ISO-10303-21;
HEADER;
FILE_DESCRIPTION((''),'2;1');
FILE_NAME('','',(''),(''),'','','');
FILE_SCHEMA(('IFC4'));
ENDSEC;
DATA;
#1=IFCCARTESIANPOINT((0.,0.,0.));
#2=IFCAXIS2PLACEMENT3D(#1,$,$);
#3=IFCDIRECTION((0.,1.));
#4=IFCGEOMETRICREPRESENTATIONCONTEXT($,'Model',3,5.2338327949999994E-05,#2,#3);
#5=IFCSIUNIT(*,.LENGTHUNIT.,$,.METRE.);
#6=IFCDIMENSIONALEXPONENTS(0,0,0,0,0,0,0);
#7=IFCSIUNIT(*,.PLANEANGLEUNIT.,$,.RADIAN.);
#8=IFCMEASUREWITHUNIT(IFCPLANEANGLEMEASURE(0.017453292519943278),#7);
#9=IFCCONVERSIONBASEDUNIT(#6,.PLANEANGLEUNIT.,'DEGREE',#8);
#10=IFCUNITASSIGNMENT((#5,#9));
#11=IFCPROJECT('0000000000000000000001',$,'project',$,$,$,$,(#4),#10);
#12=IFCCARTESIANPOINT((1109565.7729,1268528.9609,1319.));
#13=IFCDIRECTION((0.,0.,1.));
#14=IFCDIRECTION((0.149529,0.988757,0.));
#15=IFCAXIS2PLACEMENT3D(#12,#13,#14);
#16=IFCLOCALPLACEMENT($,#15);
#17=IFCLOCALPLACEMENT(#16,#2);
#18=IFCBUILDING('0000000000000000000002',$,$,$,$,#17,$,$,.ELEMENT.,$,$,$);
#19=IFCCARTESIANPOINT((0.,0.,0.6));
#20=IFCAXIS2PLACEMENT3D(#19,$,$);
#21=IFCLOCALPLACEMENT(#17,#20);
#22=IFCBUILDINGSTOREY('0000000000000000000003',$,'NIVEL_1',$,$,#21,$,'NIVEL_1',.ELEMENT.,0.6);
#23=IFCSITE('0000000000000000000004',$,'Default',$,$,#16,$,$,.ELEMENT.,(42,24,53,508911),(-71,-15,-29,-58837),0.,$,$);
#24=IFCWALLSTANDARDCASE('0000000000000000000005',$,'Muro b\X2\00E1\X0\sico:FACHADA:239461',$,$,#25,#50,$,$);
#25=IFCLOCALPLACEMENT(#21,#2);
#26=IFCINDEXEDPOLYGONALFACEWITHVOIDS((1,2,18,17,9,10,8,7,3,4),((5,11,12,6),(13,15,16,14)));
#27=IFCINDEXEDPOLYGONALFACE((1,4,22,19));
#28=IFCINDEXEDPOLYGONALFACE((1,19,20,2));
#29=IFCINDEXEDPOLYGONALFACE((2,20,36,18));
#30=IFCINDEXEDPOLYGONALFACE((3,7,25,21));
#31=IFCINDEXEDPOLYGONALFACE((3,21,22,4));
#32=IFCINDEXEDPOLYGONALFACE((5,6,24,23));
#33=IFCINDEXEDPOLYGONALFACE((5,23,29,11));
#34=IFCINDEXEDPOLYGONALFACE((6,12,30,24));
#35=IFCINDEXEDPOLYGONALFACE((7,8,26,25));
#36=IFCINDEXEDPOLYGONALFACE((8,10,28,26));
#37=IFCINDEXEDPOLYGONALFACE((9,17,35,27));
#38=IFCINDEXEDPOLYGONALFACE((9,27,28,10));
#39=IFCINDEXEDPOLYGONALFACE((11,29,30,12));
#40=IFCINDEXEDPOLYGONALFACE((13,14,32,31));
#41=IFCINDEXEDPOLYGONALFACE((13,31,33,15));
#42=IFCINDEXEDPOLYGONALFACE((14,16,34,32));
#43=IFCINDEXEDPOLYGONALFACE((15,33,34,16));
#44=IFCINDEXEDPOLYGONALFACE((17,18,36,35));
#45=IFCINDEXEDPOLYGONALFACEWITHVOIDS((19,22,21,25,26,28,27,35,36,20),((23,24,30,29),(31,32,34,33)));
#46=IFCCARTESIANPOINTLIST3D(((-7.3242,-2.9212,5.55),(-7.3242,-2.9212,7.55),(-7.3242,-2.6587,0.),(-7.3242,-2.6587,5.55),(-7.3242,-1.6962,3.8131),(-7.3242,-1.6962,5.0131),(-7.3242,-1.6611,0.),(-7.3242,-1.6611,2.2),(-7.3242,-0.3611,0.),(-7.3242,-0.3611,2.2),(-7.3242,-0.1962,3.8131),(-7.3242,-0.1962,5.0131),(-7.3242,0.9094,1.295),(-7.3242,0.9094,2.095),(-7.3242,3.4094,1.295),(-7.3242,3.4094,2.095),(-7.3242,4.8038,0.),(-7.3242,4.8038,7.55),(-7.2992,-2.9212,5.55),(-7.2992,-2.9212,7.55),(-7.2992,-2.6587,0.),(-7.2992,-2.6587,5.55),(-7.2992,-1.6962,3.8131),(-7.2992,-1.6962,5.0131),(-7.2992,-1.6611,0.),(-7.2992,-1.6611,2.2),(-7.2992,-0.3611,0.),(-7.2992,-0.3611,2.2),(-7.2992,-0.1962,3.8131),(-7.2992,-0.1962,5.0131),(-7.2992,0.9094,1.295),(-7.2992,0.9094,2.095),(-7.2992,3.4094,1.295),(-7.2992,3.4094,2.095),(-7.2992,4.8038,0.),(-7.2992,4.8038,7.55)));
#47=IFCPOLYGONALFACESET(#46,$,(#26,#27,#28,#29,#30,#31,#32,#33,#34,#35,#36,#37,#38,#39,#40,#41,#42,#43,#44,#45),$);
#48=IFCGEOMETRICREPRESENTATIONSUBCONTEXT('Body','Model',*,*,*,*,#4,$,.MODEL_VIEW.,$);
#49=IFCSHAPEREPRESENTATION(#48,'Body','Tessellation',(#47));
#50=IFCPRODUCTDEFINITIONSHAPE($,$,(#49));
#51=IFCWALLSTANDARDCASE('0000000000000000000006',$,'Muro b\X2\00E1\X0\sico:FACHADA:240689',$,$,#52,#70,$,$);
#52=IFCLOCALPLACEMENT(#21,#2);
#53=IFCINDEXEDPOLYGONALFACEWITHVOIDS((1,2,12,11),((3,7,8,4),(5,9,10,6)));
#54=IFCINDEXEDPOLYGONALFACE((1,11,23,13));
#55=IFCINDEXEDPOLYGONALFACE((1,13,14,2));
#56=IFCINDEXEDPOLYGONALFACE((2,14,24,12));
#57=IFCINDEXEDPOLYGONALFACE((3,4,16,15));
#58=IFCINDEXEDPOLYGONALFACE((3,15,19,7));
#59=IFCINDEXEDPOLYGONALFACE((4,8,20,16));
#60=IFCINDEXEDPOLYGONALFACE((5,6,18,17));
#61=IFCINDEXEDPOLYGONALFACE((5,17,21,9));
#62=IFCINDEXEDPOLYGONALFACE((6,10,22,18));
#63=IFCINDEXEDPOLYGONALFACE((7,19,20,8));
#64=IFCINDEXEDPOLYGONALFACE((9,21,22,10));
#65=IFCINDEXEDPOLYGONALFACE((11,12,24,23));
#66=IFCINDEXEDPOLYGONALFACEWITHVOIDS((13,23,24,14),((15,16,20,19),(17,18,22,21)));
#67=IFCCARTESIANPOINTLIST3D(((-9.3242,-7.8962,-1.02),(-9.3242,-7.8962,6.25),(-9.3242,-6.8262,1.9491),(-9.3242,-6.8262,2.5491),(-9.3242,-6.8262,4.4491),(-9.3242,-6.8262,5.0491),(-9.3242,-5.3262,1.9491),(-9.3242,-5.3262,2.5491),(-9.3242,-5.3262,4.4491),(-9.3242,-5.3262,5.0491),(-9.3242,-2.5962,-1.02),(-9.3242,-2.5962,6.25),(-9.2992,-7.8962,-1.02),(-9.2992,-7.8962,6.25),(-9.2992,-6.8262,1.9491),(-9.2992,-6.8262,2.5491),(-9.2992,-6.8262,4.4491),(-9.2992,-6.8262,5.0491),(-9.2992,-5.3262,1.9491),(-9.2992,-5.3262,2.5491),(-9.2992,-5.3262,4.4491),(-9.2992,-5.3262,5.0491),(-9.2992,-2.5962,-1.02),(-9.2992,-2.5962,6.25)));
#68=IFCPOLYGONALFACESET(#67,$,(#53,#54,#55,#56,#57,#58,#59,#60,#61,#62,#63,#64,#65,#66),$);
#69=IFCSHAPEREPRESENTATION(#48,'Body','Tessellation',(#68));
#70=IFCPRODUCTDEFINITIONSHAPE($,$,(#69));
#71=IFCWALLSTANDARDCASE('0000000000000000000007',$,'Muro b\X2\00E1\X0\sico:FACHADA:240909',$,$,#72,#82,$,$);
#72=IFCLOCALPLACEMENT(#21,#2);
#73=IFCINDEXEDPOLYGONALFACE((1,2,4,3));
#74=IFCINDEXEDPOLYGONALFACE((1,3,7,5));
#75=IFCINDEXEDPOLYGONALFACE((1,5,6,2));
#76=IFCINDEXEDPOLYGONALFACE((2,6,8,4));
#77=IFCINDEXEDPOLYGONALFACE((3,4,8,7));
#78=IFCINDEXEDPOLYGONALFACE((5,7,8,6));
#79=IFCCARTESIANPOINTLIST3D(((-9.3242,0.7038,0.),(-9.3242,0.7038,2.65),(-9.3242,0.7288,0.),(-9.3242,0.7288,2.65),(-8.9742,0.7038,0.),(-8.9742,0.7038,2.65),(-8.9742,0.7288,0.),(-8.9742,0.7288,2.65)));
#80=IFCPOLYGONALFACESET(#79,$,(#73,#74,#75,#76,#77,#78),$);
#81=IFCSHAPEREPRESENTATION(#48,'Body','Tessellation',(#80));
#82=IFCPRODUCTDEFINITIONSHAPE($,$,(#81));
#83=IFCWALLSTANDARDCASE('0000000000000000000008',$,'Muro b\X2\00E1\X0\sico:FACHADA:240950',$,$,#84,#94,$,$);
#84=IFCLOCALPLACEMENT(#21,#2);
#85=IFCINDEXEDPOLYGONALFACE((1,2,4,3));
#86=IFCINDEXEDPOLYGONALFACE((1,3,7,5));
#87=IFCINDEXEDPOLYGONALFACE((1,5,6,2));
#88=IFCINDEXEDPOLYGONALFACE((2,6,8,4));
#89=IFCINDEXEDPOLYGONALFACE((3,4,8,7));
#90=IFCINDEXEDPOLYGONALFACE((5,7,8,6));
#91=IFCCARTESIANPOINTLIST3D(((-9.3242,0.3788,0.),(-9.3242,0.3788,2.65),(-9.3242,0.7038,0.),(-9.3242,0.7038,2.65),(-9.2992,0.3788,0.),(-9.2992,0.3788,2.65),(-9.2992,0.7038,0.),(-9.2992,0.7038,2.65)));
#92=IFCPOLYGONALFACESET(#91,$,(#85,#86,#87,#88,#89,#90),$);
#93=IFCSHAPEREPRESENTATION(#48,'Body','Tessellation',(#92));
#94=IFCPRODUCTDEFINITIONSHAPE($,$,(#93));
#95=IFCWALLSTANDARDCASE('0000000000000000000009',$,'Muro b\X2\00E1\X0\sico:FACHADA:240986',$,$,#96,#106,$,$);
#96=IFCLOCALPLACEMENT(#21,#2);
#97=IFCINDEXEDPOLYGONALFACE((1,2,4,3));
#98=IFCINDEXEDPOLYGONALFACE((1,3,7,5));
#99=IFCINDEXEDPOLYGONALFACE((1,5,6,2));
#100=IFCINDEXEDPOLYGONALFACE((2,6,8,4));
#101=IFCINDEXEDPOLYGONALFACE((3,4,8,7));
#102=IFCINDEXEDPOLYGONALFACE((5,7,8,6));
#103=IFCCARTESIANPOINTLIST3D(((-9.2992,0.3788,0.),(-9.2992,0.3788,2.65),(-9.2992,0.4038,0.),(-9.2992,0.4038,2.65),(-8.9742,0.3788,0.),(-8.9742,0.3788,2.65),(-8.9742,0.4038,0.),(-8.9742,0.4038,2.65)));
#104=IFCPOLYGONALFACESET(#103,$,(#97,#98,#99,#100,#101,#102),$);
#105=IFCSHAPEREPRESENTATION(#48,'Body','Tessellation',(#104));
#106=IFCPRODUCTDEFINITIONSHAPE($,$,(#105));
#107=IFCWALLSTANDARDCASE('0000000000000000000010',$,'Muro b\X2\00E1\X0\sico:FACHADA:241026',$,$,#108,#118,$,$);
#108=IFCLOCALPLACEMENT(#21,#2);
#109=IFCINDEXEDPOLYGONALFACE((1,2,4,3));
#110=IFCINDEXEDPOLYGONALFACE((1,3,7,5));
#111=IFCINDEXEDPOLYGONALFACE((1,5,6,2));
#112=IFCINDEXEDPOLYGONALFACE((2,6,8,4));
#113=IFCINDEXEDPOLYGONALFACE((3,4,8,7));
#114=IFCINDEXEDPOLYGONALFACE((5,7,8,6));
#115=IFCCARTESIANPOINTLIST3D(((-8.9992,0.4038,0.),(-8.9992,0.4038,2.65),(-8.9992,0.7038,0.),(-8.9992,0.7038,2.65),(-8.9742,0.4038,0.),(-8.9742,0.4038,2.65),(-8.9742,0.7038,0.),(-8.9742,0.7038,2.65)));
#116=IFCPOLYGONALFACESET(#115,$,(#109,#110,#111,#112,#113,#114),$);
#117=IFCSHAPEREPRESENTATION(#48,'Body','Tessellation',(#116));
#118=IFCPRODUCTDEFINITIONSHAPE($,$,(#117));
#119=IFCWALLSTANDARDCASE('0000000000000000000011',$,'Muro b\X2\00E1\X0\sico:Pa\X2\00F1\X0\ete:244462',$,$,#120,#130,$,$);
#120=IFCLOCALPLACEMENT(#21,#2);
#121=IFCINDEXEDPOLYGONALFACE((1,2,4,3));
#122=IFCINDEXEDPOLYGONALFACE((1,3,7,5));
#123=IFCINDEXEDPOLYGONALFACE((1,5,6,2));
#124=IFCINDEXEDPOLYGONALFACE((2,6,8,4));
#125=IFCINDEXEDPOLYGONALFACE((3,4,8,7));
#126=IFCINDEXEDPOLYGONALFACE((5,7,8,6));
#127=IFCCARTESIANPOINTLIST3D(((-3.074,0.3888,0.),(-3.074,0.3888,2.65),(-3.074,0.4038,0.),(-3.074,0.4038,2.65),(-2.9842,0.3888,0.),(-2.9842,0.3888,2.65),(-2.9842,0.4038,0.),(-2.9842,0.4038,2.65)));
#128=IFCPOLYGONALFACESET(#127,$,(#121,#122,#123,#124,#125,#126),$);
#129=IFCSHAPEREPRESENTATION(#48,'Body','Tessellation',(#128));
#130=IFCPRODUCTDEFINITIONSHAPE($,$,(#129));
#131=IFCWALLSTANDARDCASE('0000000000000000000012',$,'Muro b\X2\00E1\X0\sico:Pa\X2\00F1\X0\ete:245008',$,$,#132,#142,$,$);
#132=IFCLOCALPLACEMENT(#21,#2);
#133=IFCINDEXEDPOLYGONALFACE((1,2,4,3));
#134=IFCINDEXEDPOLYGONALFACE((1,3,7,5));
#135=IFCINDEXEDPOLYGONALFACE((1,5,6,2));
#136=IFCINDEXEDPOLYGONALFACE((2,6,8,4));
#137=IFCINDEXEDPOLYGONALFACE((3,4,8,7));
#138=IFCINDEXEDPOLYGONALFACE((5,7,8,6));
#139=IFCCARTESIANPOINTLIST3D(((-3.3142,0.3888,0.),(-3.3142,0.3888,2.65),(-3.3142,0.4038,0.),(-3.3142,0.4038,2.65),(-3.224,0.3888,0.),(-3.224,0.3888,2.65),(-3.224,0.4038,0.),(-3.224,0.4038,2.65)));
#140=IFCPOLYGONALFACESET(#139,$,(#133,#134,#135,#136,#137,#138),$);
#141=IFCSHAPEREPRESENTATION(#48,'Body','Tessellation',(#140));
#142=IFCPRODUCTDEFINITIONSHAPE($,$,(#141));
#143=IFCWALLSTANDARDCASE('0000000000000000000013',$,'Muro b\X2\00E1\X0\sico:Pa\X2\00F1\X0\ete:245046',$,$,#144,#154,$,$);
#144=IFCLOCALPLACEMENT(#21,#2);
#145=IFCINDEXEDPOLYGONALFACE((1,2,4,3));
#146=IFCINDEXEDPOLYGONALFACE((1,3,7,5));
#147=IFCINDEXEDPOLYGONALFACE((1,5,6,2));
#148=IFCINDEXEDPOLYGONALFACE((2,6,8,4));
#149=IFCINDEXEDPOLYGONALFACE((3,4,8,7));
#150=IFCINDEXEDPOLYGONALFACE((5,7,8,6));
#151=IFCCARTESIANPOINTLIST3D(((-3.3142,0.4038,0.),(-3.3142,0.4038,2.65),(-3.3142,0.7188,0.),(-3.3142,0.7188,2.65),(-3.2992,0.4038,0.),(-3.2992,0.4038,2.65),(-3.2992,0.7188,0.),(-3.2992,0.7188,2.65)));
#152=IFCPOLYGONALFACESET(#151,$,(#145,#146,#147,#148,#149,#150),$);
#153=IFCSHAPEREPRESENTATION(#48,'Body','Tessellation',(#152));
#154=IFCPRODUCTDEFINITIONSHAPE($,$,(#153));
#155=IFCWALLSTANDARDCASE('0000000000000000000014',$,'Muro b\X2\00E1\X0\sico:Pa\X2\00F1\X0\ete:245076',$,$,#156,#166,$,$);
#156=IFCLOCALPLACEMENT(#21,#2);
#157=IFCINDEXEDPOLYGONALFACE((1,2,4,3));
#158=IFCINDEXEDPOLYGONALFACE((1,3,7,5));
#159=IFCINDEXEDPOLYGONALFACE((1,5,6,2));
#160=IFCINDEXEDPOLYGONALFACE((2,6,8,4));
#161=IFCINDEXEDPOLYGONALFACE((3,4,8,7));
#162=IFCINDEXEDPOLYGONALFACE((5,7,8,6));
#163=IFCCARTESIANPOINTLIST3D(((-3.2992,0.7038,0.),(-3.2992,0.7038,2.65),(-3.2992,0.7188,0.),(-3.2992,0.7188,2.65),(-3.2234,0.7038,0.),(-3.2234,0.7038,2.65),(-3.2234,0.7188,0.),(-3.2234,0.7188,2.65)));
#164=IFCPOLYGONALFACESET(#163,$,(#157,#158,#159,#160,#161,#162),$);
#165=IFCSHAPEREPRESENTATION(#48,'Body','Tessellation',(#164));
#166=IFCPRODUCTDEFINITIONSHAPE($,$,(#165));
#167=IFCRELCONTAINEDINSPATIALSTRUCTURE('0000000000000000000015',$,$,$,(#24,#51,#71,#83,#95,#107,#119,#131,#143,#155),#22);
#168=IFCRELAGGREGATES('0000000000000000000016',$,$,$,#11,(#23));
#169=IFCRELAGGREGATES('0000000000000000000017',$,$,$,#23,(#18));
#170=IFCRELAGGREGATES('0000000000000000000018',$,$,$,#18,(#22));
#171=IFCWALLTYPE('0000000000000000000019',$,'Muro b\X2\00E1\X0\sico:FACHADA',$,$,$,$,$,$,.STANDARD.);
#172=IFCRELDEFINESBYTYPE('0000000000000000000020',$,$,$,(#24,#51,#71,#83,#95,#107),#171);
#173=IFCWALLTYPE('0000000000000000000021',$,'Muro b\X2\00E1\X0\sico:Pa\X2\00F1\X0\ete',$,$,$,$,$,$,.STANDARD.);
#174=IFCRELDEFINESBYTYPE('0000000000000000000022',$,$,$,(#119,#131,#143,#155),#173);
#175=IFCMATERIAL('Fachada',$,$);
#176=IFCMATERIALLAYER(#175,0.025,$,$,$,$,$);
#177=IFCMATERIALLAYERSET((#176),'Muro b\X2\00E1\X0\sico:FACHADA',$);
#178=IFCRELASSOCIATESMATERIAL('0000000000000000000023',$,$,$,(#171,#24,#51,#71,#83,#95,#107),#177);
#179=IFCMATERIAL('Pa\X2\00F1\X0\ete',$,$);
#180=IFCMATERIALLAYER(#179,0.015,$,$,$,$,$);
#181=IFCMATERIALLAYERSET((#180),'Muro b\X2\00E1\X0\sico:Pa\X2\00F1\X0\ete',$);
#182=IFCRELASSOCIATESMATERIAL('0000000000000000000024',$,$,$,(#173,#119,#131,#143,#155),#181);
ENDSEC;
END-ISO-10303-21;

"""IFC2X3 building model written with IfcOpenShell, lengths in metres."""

from ifc_helpers import new_model, entity, si_unit, converted_unit, direction, frame, frame_2d, origin, place, context, subcontext, project, spatial, rectangle, extrude, material, layer, layer_set, layer_usage, type_object, element, save


model = new_model("IFC2X3")

# Units and contexts
model_context = context("Model", 3, precision=5.2338327949999994e-05, world=origin(), true_north=direction((0.0, 1.0)))
body_context = subcontext(model_context, "Body", "Model", "MODEL_VIEW")
ifc_project = project(units=[si_unit("LENGTHUNIT", "METRE"), converted_unit("PLANEANGLEUNIT", "DEGREE", entity("IfcPlaneAngleMeasure", 0.017453292519943278), si_unit("PLANEANGLEUNIT", "RADIAN"), dimensions=[0, 0, 0, 0, 0, 0, 0])], contexts=[model_context])

# Site, building, storey
site_placement = place(None, frame((1109565.7729, 1268528.9609, 1319.0), z_axis=(0.0, 0.0, 1.0), x_axis=(0.149529, 0.988757, 0.0)))
site = spatial("IfcSite", under=ifc_project, at=site_placement, Name="Default", CompositionType="ELEMENT", RefLatitude=(42, 24, 53, 508911), RefLongitude=(-71, -15, -29, -58837), RefElevation=0.0)
building_placement = place(site_placement, origin())
building = spatial("IfcBuilding", under=site, at=building_placement, CompositionType="ELEMENT")
storey_placement = place(building_placement, frame((0.0, 0.0, 0.6)))
storey = spatial("IfcBuildingStorey", under=building, at=storey_placement, Name="NIVEL_1", LongName="NIVEL_1", CompositionType="ELEMENT", Elevation=0.6)

# Shared definitions
ifc_material_1 = material(Name="Pañete")

# Walls, openings
ifc_material_2 = material(Name="Fachada")
ifc_layer_1 = layer(ifc_material_2, 0.025)
ifc_layer_set_1 = layer_set([ifc_layer_1], Name="Muro básico:FACHADA")
ifc_layer_usage_1 = layer_usage(ifc_layer_set_1, "AXIS2", "POSITIVE", -0.0125)
wall_type_1 = type_object("IfcWallType", Name="Muro básico:FACHADA", PredefinedType="STANDARD", material=ifc_layer_set_1)
wall_1_placement = place(storey_placement, frame((-7.3117, 4.8038, 0.0), z_axis=(0.0, 0.0, 1.0), x_axis=(0.0, -1.0, 0.0)))
wall_1 = element("IfcWallStandardCase", 1, at=wall_1_placement, inside=storey, type_object=wall_type_1, material=ifc_layer_usage_1, Name="Muro básico:FACHADA:239461", context=body_context, shape_type="SweptSolid", body=[
    extrude(rectangle(XDim=7.725, YDim=0.025, at=frame_2d((3.8625, 0.0), x_axis=(-1.0, 0.0))), origin(), (0.0, 0.0, 1.0), 7.55),
])
opening_1_placement = place(wall_1_placement, origin())
element("IfcOpeningElement", 2, at=opening_1_placement, cuts=wall_1, ObjectType="Opening", context=body_context, shape_type="SweptSolid", body=[
    extrude(rectangle(XDim=0.8, YDim=2.5, at=frame_2d((0.0, 0.0), x_axis=(0.0, 1.0))), frame((2.6444, 0.0125, 1.695), z_axis=(0.0, -1.0, 0.0), x_axis=(-1.0, 0.0, 0.0)), (0.0, 0.0, 1.0), 0.025),
])
opening_2_placement = place(wall_1_placement, origin())
element("IfcOpeningElement", 3, at=opening_2_placement, cuts=wall_1, ObjectType="Opening", context=body_context, shape_type="SweptSolid", body=[
    extrude(rectangle(XDim=1.2, YDim=1.5, at=frame_2d((0.0, 0.0), x_axis=(0.0, 1.0))), frame((5.75, 0.0125, 4.4131), z_axis=(0.0, -1.0, 0.0), x_axis=(-1.0, 0.0, 0.0)), (0.0, 0.0, 1.0), 0.025),
])
opening_3_placement = place(wall_1_placement, origin())
element("IfcOpeningElement", 4, at=opening_3_placement, cuts=wall_1, ObjectType="Opening", context=body_context, shape_type="SweptSolid", body=[
    extrude(rectangle(XDim=2.2, YDim=1.3, at=frame_2d((0.0, 0.0), x_axis=(0.0, 1.0))), frame((5.8149, 0.0125, 1.1), z_axis=(0.0, -1.0, 0.0), x_axis=(1.0, 0.0, 0.0)), (0.0, 0.0, 1.0), 0.025),
])
opening_4_placement = place(wall_1_placement, origin())
element("IfcOpeningElement", 5, at=opening_4_placement, cuts=wall_1, ObjectType="Opening", context=body_context, shape_type="SweptSolid", body=[
    extrude(rectangle(XDim=5.55, YDim=0.2625, at=frame_2d((0.0, 0.0), x_axis=(0.0, 1.0))), frame((7.5938, 0.0125, 2.775), z_axis=(0.0, -1.0, 0.0), x_axis=(1.0, 0.0, 0.0)), (0.0, 0.0, 1.0), 0.025),
])
ifc_layer_usage_2 = layer_usage(ifc_layer_set_1, "AXIS2", "POSITIVE", -0.0125)
wall_2_placement = place(storey_placement, frame((-9.3117, -2.5962, -1.02), z_axis=(0.0, 0.0, 1.0), x_axis=(0.0, -1.0, 0.0)))
wall_2 = element("IfcWallStandardCase", 6, at=wall_2_placement, inside=storey, type_object=wall_type_1, material=ifc_layer_usage_2, Name="Muro básico:FACHADA:240689", context=body_context, shape_type="SweptSolid", body=[
    extrude(rectangle(XDim=5.3, YDim=0.025, at=frame_2d((2.65, 0.0), x_axis=(-1.0, 0.0))), origin(), (0.0, 0.0, 1.0), 7.27),
])
opening_5_placement = place(wall_2_placement, origin())
element("IfcOpeningElement", 7, at=opening_5_placement, cuts=wall_2, ObjectType="Opening", context=body_context, shape_type="SweptSolid", body=[
    extrude(rectangle(XDim=0.6, YDim=1.5, at=frame_2d((0.0, 0.0), x_axis=(0.0, 1.0))), frame((3.48, 0.0125, 3.2691), z_axis=(0.0, -1.0, 0.0), x_axis=(-1.0, 0.0, 0.0)), (0.0, 0.0, 1.0), 0.025),
])
opening_6_placement = place(wall_2_placement, origin())
element("IfcOpeningElement", 8, at=opening_6_placement, cuts=wall_2, ObjectType="Opening", context=body_context, shape_type="SweptSolid", body=[
    extrude(rectangle(XDim=0.6, YDim=1.5, at=frame_2d((0.0, 0.0), x_axis=(0.0, 1.0))), frame((3.48, 0.0125, 5.7691), z_axis=(0.0, -1.0, 0.0), x_axis=(-1.0, 0.0, 0.0)), (0.0, 0.0, 1.0), 0.025),
])

# Walls
ifc_layer_usage_3 = layer_usage(ifc_layer_set_1, "AXIS2", "POSITIVE", -0.0125)
wall_3_placement = place(storey_placement, frame((-8.9742, 0.7163, 0.0), z_axis=(0.0, 0.0, 1.0), x_axis=(-1.0, 0.0, 0.0)))
element("IfcWallStandardCase", 9, at=wall_3_placement, inside=storey, type_object=wall_type_1, material=ifc_layer_usage_3, Name="Muro básico:FACHADA:240909", context=body_context, shape_type="SweptSolid", body=[
    extrude(rectangle(XDim=0.35, YDim=0.025, at=frame_2d((0.175, 0.0), x_axis=(-1.0, 0.0))), origin(), (0.0, 0.0, 1.0), 2.65),
])
ifc_layer_usage_4 = layer_usage(ifc_layer_set_1, "AXIS2", "POSITIVE", -0.0125)
wall_4_placement = place(storey_placement, frame((-9.3117, 0.7038, 0.0), z_axis=(0.0, 0.0, 1.0), x_axis=(0.0, -1.0, 0.0)))
element("IfcWallStandardCase", 10, at=wall_4_placement, inside=storey, type_object=wall_type_1, material=ifc_layer_usage_4, Name="Muro básico:FACHADA:240950", context=body_context, shape_type="SweptSolid", body=[
    extrude(rectangle(XDim=0.325, YDim=0.025, at=frame_2d((0.1625, 0.0), x_axis=(-1.0, 0.0))), origin(), (0.0, 0.0, 1.0), 2.65),
])
ifc_layer_usage_5 = layer_usage(ifc_layer_set_1, "AXIS2", "POSITIVE", -0.0125)
wall_5_placement = place(storey_placement, frame((-9.2992, 0.3913, 0.0)))
element("IfcWallStandardCase", 11, at=wall_5_placement, inside=storey, type_object=wall_type_1, material=ifc_layer_usage_5, Name="Muro básico:FACHADA:240986", context=body_context, shape_type="SweptSolid", body=[
    extrude(rectangle(XDim=0.325, YDim=0.025, at=frame_2d((0.1625, 0.0), x_axis=(-1.0, 0.0))), origin(), (0.0, 0.0, 1.0), 2.65),
])
ifc_layer_usage_6 = layer_usage(ifc_layer_set_1, "AXIS2", "POSITIVE", -0.0125)
wall_6_placement = place(storey_placement, frame((-8.9867, 0.4038, 0.0), z_axis=(0.0, 0.0, 1.0), x_axis=(0.0, 1.0, 0.0)))
element("IfcWallStandardCase", 12, at=wall_6_placement, inside=storey, type_object=wall_type_1, material=ifc_layer_usage_6, Name="Muro básico:FACHADA:241026", context=body_context, shape_type="SweptSolid", body=[
    extrude(rectangle(XDim=0.3, YDim=0.025, at=frame_2d((0.15, 0.0), x_axis=(-1.0, 0.0))), origin(), (0.0, 0.0, 1.0), 2.65),
])
ifc_layer_2 = layer(ifc_material_1, 0.015)
ifc_layer_set_2 = layer_set([ifc_layer_2], Name="Muro básico:Pañete")
ifc_layer_usage_7 = layer_usage(ifc_layer_set_2, "AXIS2", "POSITIVE", -0.0075)
wall_type_2 = type_object("IfcWallType", Name="Muro básico:Pañete", PredefinedType="STANDARD", material=ifc_layer_set_2)
wall_7_placement = place(storey_placement, frame((-3.074, 0.3963, 0.0)))
element("IfcWallStandardCase", 13, at=wall_7_placement, inside=storey, type_object=wall_type_2, material=ifc_layer_usage_7, Name="Muro básico:Pañete:244462", context=body_context, shape_type="SweptSolid", body=[
    extrude(rectangle(XDim=0.0898, YDim=0.015, at=frame_2d((0.0449, 0.0), x_axis=(-1.0, 0.0))), origin(), (0.0, 0.0, 1.0), 2.65),
])
ifc_layer_usage_8 = layer_usage(ifc_layer_set_2, "AXIS2", "NEGATIVE", 0.0075)
wall_8_placement = place(storey_placement, frame((-3.224, 0.3963, 0.0), z_axis=(0.0, 0.0, 1.0), x_axis=(-1.0, 0.0, 0.0)))
element("IfcWallStandardCase", 14, at=wall_8_placement, inside=storey, type_object=wall_type_2, material=ifc_layer_usage_8, Name="Muro básico:Pañete:245008", context=body_context, shape_type="SweptSolid", body=[
    extrude(rectangle(XDim=0.0902, YDim=0.015, at=frame_2d((0.0451, 0.0), x_axis=(-1.0, 0.0))), origin(), (0.0, 0.0, 1.0), 2.65),
])
ifc_layer_usage_9 = layer_usage(ifc_layer_set_2, "AXIS2", "NEGATIVE", 0.0075)
wall_9_placement = place(storey_placement, frame((-3.3067, 0.4038, 0.0), z_axis=(0.0, 0.0, 1.0), x_axis=(0.0, 1.0, 0.0)))
element("IfcWallStandardCase", 15, at=wall_9_placement, inside=storey, type_object=wall_type_2, material=ifc_layer_usage_9, Name="Muro básico:Pañete:245046", context=body_context, shape_type="SweptSolid", body=[
    extrude(rectangle(XDim=0.315, YDim=0.015, at=frame_2d((0.1575, 0.0), x_axis=(-1.0, 0.0))), origin(), (0.0, 0.0, 1.0), 2.65),
])
ifc_layer_usage_10 = layer_usage(ifc_layer_set_2, "AXIS2", "NEGATIVE", 0.0075)
wall_10_placement = place(storey_placement, frame((-3.2992, 0.7113, 0.0)))
element("IfcWallStandardCase", 16, at=wall_10_placement, inside=storey, type_object=wall_type_2, material=ifc_layer_usage_10, Name="Muro básico:Pañete:245076", context=body_context, shape_type="SweptSolid", body=[
    extrude(rectangle(XDim=0.0759, YDim=0.015, at=frame_2d((0.0379, 0.0), x_axis=(-1.0, 0.0))), origin(), (0.0, 0.0, 1.0), 2.65),
])

save(model, "model.ifc")
